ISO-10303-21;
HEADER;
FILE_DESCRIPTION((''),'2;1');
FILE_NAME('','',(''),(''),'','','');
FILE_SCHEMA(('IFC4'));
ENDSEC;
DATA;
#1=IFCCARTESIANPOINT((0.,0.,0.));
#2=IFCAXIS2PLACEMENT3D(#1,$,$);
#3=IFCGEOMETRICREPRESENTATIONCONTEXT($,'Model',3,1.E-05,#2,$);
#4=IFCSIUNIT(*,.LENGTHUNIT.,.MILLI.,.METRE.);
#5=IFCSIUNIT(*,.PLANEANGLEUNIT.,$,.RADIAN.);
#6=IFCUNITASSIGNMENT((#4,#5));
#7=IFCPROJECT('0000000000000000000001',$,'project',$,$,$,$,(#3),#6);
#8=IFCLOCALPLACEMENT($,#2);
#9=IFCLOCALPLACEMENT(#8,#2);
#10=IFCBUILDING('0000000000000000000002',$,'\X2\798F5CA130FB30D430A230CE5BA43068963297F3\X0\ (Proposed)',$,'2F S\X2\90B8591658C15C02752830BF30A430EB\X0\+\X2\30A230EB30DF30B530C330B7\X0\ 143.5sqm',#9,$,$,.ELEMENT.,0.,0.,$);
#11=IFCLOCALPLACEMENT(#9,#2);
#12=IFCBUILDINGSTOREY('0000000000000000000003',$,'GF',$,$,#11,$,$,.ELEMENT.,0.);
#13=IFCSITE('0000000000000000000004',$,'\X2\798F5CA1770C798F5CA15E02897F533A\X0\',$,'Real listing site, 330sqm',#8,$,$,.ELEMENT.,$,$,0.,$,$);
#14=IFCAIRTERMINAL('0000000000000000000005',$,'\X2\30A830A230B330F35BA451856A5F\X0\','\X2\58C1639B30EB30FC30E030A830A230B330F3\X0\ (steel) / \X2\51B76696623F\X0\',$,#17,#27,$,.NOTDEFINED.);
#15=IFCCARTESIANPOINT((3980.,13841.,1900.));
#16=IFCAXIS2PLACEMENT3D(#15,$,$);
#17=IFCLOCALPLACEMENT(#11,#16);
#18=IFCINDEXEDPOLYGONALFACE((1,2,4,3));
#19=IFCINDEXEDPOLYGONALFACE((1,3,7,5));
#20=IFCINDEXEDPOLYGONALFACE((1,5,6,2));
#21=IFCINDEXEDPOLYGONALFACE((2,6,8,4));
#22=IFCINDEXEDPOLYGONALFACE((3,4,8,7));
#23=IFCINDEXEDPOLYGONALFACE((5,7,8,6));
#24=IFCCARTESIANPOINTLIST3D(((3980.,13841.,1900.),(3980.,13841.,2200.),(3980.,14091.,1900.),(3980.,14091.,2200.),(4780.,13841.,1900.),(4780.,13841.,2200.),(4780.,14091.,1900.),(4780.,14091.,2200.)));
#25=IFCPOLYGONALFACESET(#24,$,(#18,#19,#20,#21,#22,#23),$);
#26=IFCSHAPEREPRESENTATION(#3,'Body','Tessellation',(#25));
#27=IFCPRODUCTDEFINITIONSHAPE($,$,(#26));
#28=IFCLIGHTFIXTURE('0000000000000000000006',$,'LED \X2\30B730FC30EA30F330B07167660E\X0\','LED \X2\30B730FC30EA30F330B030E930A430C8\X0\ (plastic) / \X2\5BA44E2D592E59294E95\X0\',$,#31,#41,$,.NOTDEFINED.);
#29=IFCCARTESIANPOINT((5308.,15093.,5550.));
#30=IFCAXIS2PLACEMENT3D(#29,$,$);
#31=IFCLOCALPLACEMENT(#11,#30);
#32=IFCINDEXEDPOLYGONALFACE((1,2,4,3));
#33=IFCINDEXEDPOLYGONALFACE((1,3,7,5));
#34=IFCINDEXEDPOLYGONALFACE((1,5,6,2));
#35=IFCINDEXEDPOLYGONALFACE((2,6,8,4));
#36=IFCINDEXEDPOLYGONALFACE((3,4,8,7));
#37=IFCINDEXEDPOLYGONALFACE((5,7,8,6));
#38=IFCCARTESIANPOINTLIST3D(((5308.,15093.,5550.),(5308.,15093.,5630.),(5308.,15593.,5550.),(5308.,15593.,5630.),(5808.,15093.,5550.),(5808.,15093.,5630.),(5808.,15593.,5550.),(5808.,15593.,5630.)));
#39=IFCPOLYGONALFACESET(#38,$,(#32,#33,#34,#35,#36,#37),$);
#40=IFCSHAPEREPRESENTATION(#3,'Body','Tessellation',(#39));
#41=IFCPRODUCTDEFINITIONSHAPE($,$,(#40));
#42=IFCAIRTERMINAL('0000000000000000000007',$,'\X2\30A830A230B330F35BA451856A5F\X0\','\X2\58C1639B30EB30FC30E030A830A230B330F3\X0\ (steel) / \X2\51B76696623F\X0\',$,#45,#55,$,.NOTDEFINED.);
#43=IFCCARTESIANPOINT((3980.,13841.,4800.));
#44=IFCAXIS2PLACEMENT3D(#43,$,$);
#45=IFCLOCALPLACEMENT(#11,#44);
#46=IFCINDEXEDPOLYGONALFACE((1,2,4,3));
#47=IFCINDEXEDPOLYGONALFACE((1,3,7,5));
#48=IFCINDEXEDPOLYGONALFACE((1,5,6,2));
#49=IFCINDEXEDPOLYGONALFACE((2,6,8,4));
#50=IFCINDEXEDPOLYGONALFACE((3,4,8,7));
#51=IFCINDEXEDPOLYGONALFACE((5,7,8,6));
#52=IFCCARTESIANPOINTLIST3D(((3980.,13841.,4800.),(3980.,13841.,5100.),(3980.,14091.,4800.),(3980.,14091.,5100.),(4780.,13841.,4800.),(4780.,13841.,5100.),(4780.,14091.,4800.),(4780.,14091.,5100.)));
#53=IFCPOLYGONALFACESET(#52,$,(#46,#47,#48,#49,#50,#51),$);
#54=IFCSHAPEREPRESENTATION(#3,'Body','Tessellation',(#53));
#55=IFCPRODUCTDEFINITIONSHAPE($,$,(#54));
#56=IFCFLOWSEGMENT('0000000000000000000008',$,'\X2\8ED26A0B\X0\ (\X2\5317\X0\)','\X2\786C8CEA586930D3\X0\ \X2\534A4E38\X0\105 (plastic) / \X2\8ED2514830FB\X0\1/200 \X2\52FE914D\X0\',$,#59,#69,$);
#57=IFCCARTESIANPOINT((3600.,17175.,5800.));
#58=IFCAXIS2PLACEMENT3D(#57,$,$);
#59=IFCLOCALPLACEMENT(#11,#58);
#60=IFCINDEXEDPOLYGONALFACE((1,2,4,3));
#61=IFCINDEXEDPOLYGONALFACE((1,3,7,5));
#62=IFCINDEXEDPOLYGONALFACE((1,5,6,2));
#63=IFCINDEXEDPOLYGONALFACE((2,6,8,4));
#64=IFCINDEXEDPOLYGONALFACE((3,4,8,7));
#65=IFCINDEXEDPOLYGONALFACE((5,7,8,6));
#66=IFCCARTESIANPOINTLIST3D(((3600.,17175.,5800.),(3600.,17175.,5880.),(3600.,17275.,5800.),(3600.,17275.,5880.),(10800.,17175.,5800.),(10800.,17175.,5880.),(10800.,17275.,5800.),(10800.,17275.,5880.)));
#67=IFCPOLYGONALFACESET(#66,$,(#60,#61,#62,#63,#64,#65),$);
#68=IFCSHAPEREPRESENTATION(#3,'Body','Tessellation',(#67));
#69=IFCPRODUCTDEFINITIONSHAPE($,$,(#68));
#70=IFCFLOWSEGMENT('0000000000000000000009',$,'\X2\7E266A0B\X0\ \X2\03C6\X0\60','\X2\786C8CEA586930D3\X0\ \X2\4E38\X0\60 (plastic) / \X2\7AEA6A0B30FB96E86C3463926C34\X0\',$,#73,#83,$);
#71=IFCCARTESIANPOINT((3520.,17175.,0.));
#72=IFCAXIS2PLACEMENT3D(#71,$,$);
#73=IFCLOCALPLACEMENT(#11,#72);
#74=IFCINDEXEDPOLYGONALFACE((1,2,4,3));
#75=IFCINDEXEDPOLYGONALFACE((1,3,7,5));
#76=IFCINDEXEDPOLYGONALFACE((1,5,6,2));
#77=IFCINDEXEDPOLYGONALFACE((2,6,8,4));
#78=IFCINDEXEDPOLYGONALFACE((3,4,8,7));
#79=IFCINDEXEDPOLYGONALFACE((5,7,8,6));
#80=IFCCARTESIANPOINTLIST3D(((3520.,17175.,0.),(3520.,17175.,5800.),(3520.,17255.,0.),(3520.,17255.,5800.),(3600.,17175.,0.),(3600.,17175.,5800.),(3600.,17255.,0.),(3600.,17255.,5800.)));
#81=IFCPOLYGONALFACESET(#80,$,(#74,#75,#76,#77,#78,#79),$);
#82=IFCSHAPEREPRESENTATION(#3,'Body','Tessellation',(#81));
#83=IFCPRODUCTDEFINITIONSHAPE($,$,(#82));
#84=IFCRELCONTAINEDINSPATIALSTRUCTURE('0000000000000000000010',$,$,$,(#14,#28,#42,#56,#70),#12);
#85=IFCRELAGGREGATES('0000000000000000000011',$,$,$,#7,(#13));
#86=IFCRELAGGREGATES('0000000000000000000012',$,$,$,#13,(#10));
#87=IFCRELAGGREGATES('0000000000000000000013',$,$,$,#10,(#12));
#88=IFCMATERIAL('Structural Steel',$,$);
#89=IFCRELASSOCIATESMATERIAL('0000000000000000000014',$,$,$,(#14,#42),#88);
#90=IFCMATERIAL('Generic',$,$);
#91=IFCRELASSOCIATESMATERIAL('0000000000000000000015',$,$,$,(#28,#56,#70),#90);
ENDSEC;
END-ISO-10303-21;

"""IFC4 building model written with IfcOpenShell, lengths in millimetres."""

from ifc_helpers import new_model, si_unit, frame, frame_2d, origin, place, context, project, spatial, rectangle, extrude, material, element, save


model = new_model("IFC4")

# Units and contexts
model_context = context("Model", 3, precision=1e-05, world=origin())
ifc_project = project(units=[si_unit("LENGTHUNIT", "METRE", prefix="MILLI"), si_unit("PLANEANGLEUNIT", "RADIAN")], contexts=[model_context])

# Site, building, storey
site_placement = place(None, origin())
site = spatial("IfcSite", under=ifc_project, at=site_placement, Name="福岡県福岡市西区", ObjectType="Real listing site, 330sqm", CompositionType="ELEMENT", RefElevation=0.0)
building_placement = place(site_placement, origin())
building = spatial("IfcBuilding", under=site, at=building_placement, Name="福岡・ピアノ室と防音 (Proposed)", ObjectType="2F S邸外壁専用タイル+アルミサッシ 143.5sqm", CompositionType="ELEMENT", ElevationOfRefHeight=0.0, ElevationOfTerrain=0.0)
storey_placement = place(building_placement, origin())
storey = spatial("IfcBuildingStorey", under=building, at=storey_placement, Name="GF", CompositionType="ELEMENT", Elevation=0.0)

# Shared definitions
ifc_material_1 = material(Name="Generic")

# Shared definitions
ifc_material_2 = material(Name="Structural Steel")

# Air terminal
air_terminal_1_placement = place(storey_placement, frame((3980.0, 13841.0, 1900.0)))
element("IfcAirTerminal", 1, at=air_terminal_1_placement, inside=storey, material=ifc_material_2, Name="エアコン室内機", Description="壁掛ルームエアコン (steel) / 冷暖房", PredefinedType="NOTDEFINED", context=model_context, shape_type="SweptSolid", body=[
    extrude(rectangle(XDim=800.0, YDim=250.0, at=frame_2d((400.0, 125.0))), frame((3980.0, 13841.0, 1900.0)), (0.0, 0.0, 1.0), 300.0),
])

# Light fixture
light_fixture_placement = place(storey_placement, frame((5308.0, 15093.0, 5550.0)))
element("IfcLightFixture", 2, at=light_fixture_placement, inside=storey, material=ifc_material_1, Name="LED シーリング照明", Description="LED シーリングライト (plastic) / 室中央天井", PredefinedType="NOTDEFINED", context=model_context, shape_type="SweptSolid", body=[
    extrude(rectangle(XDim=500.0, YDim=500.0, at=frame_2d((250.0, 250.0))), frame((5308.0, 15093.0, 5550.0)), (0.0, 0.0, 1.0), 80.0),
])

# Air terminal
air_terminal_2_placement = place(storey_placement, frame((3980.0, 13841.0, 4800.0)))
element("IfcAirTerminal", 3, at=air_terminal_2_placement, inside=storey, material=ifc_material_2, Name="エアコン室内機", Description="壁掛ルームエアコン (steel) / 冷暖房", PredefinedType="NOTDEFINED", context=model_context, shape_type="SweptSolid", body=[
    extrude(rectangle(XDim=800.0, YDim=250.0, at=frame_2d((400.0, 125.0))), frame((3980.0, 13841.0, 4800.0)), (0.0, 0.0, 1.0), 300.0),
])

# Flow segments
flow_segment_1_placement = place(storey_placement, frame((3600.0, 17175.0, 5800.0)))
element("IfcFlowSegment", 4, at=flow_segment_1_placement, inside=storey, material=ifc_material_1, Name="軒樋 (北)", Description="硬質塩ビ 半丸105 (plastic) / 軒先・1/200 勾配", context=model_context, shape_type="SweptSolid", body=[
    extrude(rectangle(XDim=7200.0, YDim=100.0, at=frame_2d((3600.0, 50.0))), frame((3600.0, 17175.0, 5800.0)), (0.0, 0.0, 1.0), 80.0),
])
flow_segment_2_placement = place(storey_placement, frame((3520.0, 17175.0, 0.0)))
element("IfcFlowSegment", 5, at=flow_segment_2_placement, inside=storey, material=ifc_material_1, Name="縦樋 φ60", Description="硬質塩ビ 丸60 (plastic) / 竪樋・雨水排水", context=model_context, shape_type="SweptSolid", body=[
    extrude(rectangle(XDim=80.0, YDim=80.0, at=frame_2d((40.0, 40.0))), frame((3520.0, 17175.0, 0.0)), (0.0, 0.0, 1.0), 5800.0),
])

save(model, "model.ifc")
